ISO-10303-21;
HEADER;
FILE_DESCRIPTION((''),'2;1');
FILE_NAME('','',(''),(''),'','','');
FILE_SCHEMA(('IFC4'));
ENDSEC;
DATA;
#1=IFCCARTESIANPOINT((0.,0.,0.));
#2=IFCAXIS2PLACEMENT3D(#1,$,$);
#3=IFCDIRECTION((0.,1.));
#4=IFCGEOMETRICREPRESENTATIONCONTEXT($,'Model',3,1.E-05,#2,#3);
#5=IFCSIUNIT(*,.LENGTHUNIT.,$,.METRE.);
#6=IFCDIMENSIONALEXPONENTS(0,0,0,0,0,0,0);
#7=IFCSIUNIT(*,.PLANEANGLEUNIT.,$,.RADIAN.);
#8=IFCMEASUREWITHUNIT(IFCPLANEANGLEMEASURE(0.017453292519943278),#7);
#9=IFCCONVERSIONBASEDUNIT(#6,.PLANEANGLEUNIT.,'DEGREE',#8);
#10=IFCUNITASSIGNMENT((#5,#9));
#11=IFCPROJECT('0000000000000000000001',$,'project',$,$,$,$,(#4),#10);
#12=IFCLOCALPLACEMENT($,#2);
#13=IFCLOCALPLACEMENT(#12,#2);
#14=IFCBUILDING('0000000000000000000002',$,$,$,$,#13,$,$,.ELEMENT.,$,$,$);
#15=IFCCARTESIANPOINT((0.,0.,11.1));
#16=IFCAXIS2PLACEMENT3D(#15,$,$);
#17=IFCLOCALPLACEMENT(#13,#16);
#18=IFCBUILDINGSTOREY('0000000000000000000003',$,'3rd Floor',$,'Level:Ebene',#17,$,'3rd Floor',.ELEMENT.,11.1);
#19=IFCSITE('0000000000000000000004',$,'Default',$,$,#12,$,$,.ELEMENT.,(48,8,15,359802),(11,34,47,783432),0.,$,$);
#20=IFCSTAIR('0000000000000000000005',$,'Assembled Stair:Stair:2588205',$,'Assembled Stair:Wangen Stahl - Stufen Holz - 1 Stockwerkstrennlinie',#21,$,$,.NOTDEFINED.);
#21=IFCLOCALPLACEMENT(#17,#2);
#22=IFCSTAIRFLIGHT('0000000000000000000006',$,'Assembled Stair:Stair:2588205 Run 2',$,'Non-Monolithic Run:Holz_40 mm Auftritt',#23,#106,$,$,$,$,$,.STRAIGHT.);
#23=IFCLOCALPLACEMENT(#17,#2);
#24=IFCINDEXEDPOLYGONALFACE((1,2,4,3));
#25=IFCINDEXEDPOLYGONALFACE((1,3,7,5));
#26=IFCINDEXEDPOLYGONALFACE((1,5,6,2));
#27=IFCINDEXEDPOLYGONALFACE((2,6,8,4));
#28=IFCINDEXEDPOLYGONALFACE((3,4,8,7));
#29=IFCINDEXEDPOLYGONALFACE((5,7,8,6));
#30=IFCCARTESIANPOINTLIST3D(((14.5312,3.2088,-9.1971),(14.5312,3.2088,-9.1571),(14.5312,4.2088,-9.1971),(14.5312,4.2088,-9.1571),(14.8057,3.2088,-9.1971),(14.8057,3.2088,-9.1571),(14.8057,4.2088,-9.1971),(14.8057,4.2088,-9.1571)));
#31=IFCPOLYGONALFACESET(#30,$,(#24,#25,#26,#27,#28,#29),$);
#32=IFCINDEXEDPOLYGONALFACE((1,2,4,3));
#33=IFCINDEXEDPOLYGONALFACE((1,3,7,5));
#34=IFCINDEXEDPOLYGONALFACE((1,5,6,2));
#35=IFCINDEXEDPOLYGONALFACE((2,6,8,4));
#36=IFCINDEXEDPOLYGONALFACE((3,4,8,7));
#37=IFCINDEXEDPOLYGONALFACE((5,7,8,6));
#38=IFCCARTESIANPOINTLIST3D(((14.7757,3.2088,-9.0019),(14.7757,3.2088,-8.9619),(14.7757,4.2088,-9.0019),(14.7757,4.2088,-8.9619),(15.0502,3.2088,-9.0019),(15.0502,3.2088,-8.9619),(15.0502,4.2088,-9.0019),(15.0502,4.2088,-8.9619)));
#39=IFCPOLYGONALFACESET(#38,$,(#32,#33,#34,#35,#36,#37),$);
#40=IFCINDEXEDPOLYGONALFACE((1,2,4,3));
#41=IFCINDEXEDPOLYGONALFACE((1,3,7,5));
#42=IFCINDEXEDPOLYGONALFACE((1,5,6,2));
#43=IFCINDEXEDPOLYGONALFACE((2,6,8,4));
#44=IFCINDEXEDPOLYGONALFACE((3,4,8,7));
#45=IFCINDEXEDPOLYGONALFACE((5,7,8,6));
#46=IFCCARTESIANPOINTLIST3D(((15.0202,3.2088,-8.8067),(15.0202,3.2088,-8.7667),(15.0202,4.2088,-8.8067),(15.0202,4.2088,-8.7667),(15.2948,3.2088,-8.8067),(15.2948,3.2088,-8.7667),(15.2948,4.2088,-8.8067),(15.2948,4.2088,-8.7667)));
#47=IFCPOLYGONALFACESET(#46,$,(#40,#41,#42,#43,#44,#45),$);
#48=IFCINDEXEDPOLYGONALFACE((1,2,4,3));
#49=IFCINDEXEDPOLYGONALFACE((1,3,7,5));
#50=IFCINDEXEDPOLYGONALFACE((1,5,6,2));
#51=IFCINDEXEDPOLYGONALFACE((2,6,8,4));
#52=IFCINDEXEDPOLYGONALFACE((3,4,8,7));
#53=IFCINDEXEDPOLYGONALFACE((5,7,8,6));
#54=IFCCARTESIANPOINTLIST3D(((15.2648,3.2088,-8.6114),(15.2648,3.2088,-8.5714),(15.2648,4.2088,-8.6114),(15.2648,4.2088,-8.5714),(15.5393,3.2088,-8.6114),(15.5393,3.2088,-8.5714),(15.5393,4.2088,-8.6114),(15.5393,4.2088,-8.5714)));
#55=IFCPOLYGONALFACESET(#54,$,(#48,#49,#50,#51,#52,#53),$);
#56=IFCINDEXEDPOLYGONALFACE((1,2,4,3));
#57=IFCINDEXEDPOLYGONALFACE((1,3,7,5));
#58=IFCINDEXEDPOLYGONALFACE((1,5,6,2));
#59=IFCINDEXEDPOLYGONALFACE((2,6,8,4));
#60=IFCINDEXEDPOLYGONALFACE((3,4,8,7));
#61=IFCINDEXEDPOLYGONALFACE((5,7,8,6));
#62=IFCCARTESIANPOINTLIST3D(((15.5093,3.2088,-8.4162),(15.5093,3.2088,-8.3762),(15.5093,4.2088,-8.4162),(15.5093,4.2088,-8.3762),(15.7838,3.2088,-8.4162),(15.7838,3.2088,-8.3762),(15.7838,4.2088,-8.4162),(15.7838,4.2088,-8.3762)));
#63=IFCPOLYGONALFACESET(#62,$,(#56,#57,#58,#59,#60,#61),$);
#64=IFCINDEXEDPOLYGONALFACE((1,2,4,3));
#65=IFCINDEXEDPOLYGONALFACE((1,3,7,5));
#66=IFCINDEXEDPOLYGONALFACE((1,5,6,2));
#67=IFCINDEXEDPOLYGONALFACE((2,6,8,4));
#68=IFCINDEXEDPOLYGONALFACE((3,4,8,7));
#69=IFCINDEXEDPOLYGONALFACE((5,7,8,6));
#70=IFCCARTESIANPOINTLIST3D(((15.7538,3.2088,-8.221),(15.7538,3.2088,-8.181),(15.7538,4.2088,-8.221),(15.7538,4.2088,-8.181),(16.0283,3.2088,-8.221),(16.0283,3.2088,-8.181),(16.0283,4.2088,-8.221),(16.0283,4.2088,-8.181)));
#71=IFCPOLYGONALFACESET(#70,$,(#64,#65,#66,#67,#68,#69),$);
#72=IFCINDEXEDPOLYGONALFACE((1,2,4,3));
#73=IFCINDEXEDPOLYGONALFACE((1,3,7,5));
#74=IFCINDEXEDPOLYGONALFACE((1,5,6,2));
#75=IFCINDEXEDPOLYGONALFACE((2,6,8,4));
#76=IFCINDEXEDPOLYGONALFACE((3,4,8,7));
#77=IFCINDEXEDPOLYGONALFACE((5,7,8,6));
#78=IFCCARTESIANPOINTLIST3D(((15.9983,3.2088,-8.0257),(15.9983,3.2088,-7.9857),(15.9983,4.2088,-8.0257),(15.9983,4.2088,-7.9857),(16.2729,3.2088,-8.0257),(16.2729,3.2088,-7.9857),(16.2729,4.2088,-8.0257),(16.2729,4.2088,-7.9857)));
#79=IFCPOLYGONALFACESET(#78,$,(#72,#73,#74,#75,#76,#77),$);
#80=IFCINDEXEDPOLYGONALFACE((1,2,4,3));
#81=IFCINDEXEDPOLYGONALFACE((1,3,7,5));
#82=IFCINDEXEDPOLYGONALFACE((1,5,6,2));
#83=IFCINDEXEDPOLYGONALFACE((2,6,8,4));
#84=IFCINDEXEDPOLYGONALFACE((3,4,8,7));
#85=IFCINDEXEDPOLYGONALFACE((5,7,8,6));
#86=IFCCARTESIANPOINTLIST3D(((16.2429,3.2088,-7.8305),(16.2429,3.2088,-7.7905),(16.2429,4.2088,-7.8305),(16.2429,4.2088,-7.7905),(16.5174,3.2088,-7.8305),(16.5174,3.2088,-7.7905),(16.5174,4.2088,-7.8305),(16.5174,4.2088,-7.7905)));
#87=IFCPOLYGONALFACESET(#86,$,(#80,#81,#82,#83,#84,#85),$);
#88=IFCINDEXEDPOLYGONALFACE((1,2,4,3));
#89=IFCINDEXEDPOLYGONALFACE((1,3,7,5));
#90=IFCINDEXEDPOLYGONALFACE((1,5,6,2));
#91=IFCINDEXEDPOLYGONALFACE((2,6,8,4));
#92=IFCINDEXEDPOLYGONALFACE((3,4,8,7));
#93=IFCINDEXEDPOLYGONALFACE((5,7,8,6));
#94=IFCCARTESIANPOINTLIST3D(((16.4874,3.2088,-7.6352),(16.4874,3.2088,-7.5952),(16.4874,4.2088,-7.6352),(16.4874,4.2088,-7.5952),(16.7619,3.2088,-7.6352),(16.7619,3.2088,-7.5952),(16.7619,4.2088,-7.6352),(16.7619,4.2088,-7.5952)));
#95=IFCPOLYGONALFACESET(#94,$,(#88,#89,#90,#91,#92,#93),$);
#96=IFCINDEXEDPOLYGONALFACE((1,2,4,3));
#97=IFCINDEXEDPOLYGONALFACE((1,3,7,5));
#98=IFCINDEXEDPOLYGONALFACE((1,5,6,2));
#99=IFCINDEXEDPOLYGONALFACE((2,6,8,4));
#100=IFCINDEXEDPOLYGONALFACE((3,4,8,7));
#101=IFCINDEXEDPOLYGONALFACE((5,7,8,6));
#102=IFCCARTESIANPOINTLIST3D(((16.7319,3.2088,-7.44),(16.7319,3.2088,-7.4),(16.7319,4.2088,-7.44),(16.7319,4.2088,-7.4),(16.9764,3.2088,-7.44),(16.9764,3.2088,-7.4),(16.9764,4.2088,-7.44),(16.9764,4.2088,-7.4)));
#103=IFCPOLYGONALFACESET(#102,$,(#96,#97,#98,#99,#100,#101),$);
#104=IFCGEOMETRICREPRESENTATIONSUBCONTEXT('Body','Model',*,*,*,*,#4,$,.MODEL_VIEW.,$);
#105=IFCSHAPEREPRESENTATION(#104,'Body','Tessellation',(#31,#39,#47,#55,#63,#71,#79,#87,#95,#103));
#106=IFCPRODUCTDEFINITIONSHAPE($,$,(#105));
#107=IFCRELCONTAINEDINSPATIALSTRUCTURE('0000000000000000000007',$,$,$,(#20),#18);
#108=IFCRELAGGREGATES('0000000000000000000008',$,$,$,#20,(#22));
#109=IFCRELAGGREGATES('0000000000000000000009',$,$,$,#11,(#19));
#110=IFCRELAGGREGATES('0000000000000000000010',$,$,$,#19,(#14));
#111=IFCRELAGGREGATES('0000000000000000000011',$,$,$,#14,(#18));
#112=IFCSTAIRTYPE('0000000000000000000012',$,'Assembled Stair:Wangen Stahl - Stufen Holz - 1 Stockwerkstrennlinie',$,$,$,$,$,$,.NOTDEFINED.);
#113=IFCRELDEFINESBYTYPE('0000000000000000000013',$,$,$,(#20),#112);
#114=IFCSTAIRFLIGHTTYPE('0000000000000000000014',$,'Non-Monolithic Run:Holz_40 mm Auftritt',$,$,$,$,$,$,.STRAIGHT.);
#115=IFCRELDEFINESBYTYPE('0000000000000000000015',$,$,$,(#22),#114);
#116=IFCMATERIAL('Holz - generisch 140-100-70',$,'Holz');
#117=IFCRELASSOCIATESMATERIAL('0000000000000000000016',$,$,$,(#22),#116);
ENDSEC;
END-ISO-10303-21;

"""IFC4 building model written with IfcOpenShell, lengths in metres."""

from ifc_helpers import new_model, entity, si_unit, converted_unit, direction, frame, origin, place, context, subcontext, project, spatial, indexed_curve, outline, extrude, material, type_object, element, aggregate, save


model = new_model("IFC4")

# Units and contexts
model_context = context("Model", 3, precision=1e-05, world=origin(), true_north=direction((0.0, 1.0)))
body_context = subcontext(model_context, "Body", "Model", "MODEL_VIEW")
ifc_project = project(units=[si_unit("LENGTHUNIT", "METRE"), converted_unit("PLANEANGLEUNIT", "DEGREE", entity("IfcPlaneAngleMeasure", 0.017453292519943278), si_unit("PLANEANGLEUNIT", "RADIAN"), dimensions=[0, 0, 0, 0, 0, 0, 0])], contexts=[model_context])

# Site, building, storey
site_placement = place(None, origin())
site = spatial("IfcSite", under=ifc_project, at=site_placement, Name="Default", CompositionType="ELEMENT", RefLatitude=(48, 8, 15, 359802), RefLongitude=(11, 34, 47, 783432), RefElevation=0.0)
building_placement = place(site_placement, origin())
building = spatial("IfcBuilding", under=site, at=building_placement, CompositionType="ELEMENT")
storey_placement = place(building_placement, frame((0.0, 0.0, 11.1)))
storey = spatial("IfcBuildingStorey", under=building, at=storey_placement, Name="3rd Floor", ObjectType="Level:Ebene", LongName="3rd Floor", CompositionType="ELEMENT", Elevation=11.1)

# Stair
stair_type = type_object("IfcStairType", Name="Assembled Stair:Wangen Stahl - Stufen Holz - 1 Stockwerkstrennlinie", PredefinedType="NOTDEFINED")
stair_placement = place(storey_placement, origin())
stair = element("IfcStair", 1, at=stair_placement, inside=storey, type_object=stair_type, Name="Assembled Stair:Stair:2588205", ObjectType="Assembled Stair:Wangen Stahl - Stufen Holz - 1 Stockwerkstrennlinie", PredefinedType="NOTDEFINED")

# Shared definitions
ifc_material_1 = material(Name="Holz - generisch 140-100-70", Category="Holz")

# Stair flight
stair_flight_type = type_object("IfcStairFlightType", Name="Non-Monolithic Run:Holz_40 mm Auftritt", PredefinedType="STRAIGHT")
stair_flight_1_placement = place(stair_placement, origin())
stair_flight_1 = element("IfcStairFlight", 2, at=stair_flight_1_placement, type_object=stair_flight_type, material=ifc_material_1, Name="Assembled Stair:Stair:2588205 Run 2", ObjectType="Non-Monolithic Run:Holz_40 mm Auftritt", PredefinedType="STRAIGHT", context=body_context, shape_type="SweptSolid", body=[
    extrude(outline(indexed_curve([(-0.1373, -0.5), (0.1373, -0.5), (0.1373, 0.5), (-0.1373, 0.5), (-0.1373, -0.5)], self_intersect=False)), frame((14.6685, 3.7088, -9.1971), z_axis=(0.0, 0.0, 1.0), x_axis=(-1.0, 0.0, 0.0)), (0.0, 0.0, 1.0), 0.04),
    extrude(outline(indexed_curve([(-0.1373, -0.5), (0.1373, -0.5), (0.1373, 0.5), (-0.1373, 0.5), (-0.1373, -0.5)], self_intersect=False)), frame((14.913, 3.7088, -9.0019), z_axis=(0.0, 0.0, 1.0), x_axis=(-1.0, 0.0, 0.0)), (0.0, 0.0, 1.0), 0.04),
    extrude(outline(indexed_curve([(-0.1373, -0.5), (0.1373, -0.5), (0.1373, 0.5), (-0.1373, 0.5), (-0.1373, -0.5)], self_intersect=False)), frame((15.1575, 3.7088, -8.8067), z_axis=(0.0, 0.0, 1.0), x_axis=(-1.0, 0.0, 0.0)), (0.0, 0.0, 1.0), 0.04),
    extrude(outline(indexed_curve([(-0.1373, -0.5), (0.1373, -0.5), (0.1373, 0.5), (-0.1373, 0.5), (-0.1373, -0.5)], self_intersect=False)), frame((15.402, 3.7088, -8.6114), z_axis=(0.0, 0.0, 1.0), x_axis=(-1.0, 0.0, 0.0)), (0.0, 0.0, 1.0), 0.04),
    extrude(outline(indexed_curve([(-0.1373, -0.5), (0.1373, -0.5), (0.1373, 0.5), (-0.1373, 0.5), (-0.1373, -0.5)], self_intersect=False)), frame((15.6466, 3.7088, -8.4162), z_axis=(0.0, 0.0, 1.0), x_axis=(-1.0, 0.0, 0.0)), (0.0, 0.0, 1.0), 0.04),
    extrude(outline(indexed_curve([(-0.1373, -0.5), (0.1373, -0.5), (0.1373, 0.5), (-0.1373, 0.5), (-0.1373, -0.5)], self_intersect=False)), frame((15.8911, 3.7088, -8.221), z_axis=(0.0, 0.0, 1.0), x_axis=(-1.0, 0.0, 0.0)), (0.0, 0.0, 1.0), 0.04),
    extrude(outline(indexed_curve([(-0.1373, -0.5), (0.1373, -0.5), (0.1373, 0.5), (-0.1373, 0.5), (-0.1373, -0.5)], self_intersect=False)), frame((16.1356, 3.7088, -8.0257), z_axis=(0.0, 0.0, 1.0), x_axis=(-1.0, 0.0, 0.0)), (0.0, 0.0, 1.0), 0.04),
    extrude(outline(indexed_curve([(-0.1373, -0.5), (0.1373, -0.5), (0.1373, 0.5), (-0.1373, 0.5), (-0.1373, -0.5)], self_intersect=False)), frame((16.3801, 3.7088, -7.8305), z_axis=(0.0, 0.0, 1.0), x_axis=(-1.0, 0.0, 0.0)), (0.0, 0.0, 1.0), 0.04),
    extrude(outline(indexed_curve([(-0.1373, -0.5), (0.1373, -0.5), (0.1373, 0.5), (-0.1373, 0.5), (-0.1373, -0.5)], self_intersect=False)), frame((16.6246, 3.7088, -7.6352), z_axis=(0.0, 0.0, 1.0), x_axis=(-1.0, 0.0, 0.0)), (0.0, 0.0, 1.0), 0.04),
    extrude(outline(indexed_curve([(-0.1223, -0.5), (0.1223, -0.5), (0.1223, 0.5), (-0.1223, 0.5), (-0.1223, -0.5)], self_intersect=False)), frame((16.8542, 3.7088, -7.44), z_axis=(0.0, 0.0, 1.0), x_axis=(-1.0, 0.0, 0.0)), (0.0, 0.0, 1.0), 0.04),
])
aggregate(stair, [stair_flight_1])

save(model, "model.ifc")
